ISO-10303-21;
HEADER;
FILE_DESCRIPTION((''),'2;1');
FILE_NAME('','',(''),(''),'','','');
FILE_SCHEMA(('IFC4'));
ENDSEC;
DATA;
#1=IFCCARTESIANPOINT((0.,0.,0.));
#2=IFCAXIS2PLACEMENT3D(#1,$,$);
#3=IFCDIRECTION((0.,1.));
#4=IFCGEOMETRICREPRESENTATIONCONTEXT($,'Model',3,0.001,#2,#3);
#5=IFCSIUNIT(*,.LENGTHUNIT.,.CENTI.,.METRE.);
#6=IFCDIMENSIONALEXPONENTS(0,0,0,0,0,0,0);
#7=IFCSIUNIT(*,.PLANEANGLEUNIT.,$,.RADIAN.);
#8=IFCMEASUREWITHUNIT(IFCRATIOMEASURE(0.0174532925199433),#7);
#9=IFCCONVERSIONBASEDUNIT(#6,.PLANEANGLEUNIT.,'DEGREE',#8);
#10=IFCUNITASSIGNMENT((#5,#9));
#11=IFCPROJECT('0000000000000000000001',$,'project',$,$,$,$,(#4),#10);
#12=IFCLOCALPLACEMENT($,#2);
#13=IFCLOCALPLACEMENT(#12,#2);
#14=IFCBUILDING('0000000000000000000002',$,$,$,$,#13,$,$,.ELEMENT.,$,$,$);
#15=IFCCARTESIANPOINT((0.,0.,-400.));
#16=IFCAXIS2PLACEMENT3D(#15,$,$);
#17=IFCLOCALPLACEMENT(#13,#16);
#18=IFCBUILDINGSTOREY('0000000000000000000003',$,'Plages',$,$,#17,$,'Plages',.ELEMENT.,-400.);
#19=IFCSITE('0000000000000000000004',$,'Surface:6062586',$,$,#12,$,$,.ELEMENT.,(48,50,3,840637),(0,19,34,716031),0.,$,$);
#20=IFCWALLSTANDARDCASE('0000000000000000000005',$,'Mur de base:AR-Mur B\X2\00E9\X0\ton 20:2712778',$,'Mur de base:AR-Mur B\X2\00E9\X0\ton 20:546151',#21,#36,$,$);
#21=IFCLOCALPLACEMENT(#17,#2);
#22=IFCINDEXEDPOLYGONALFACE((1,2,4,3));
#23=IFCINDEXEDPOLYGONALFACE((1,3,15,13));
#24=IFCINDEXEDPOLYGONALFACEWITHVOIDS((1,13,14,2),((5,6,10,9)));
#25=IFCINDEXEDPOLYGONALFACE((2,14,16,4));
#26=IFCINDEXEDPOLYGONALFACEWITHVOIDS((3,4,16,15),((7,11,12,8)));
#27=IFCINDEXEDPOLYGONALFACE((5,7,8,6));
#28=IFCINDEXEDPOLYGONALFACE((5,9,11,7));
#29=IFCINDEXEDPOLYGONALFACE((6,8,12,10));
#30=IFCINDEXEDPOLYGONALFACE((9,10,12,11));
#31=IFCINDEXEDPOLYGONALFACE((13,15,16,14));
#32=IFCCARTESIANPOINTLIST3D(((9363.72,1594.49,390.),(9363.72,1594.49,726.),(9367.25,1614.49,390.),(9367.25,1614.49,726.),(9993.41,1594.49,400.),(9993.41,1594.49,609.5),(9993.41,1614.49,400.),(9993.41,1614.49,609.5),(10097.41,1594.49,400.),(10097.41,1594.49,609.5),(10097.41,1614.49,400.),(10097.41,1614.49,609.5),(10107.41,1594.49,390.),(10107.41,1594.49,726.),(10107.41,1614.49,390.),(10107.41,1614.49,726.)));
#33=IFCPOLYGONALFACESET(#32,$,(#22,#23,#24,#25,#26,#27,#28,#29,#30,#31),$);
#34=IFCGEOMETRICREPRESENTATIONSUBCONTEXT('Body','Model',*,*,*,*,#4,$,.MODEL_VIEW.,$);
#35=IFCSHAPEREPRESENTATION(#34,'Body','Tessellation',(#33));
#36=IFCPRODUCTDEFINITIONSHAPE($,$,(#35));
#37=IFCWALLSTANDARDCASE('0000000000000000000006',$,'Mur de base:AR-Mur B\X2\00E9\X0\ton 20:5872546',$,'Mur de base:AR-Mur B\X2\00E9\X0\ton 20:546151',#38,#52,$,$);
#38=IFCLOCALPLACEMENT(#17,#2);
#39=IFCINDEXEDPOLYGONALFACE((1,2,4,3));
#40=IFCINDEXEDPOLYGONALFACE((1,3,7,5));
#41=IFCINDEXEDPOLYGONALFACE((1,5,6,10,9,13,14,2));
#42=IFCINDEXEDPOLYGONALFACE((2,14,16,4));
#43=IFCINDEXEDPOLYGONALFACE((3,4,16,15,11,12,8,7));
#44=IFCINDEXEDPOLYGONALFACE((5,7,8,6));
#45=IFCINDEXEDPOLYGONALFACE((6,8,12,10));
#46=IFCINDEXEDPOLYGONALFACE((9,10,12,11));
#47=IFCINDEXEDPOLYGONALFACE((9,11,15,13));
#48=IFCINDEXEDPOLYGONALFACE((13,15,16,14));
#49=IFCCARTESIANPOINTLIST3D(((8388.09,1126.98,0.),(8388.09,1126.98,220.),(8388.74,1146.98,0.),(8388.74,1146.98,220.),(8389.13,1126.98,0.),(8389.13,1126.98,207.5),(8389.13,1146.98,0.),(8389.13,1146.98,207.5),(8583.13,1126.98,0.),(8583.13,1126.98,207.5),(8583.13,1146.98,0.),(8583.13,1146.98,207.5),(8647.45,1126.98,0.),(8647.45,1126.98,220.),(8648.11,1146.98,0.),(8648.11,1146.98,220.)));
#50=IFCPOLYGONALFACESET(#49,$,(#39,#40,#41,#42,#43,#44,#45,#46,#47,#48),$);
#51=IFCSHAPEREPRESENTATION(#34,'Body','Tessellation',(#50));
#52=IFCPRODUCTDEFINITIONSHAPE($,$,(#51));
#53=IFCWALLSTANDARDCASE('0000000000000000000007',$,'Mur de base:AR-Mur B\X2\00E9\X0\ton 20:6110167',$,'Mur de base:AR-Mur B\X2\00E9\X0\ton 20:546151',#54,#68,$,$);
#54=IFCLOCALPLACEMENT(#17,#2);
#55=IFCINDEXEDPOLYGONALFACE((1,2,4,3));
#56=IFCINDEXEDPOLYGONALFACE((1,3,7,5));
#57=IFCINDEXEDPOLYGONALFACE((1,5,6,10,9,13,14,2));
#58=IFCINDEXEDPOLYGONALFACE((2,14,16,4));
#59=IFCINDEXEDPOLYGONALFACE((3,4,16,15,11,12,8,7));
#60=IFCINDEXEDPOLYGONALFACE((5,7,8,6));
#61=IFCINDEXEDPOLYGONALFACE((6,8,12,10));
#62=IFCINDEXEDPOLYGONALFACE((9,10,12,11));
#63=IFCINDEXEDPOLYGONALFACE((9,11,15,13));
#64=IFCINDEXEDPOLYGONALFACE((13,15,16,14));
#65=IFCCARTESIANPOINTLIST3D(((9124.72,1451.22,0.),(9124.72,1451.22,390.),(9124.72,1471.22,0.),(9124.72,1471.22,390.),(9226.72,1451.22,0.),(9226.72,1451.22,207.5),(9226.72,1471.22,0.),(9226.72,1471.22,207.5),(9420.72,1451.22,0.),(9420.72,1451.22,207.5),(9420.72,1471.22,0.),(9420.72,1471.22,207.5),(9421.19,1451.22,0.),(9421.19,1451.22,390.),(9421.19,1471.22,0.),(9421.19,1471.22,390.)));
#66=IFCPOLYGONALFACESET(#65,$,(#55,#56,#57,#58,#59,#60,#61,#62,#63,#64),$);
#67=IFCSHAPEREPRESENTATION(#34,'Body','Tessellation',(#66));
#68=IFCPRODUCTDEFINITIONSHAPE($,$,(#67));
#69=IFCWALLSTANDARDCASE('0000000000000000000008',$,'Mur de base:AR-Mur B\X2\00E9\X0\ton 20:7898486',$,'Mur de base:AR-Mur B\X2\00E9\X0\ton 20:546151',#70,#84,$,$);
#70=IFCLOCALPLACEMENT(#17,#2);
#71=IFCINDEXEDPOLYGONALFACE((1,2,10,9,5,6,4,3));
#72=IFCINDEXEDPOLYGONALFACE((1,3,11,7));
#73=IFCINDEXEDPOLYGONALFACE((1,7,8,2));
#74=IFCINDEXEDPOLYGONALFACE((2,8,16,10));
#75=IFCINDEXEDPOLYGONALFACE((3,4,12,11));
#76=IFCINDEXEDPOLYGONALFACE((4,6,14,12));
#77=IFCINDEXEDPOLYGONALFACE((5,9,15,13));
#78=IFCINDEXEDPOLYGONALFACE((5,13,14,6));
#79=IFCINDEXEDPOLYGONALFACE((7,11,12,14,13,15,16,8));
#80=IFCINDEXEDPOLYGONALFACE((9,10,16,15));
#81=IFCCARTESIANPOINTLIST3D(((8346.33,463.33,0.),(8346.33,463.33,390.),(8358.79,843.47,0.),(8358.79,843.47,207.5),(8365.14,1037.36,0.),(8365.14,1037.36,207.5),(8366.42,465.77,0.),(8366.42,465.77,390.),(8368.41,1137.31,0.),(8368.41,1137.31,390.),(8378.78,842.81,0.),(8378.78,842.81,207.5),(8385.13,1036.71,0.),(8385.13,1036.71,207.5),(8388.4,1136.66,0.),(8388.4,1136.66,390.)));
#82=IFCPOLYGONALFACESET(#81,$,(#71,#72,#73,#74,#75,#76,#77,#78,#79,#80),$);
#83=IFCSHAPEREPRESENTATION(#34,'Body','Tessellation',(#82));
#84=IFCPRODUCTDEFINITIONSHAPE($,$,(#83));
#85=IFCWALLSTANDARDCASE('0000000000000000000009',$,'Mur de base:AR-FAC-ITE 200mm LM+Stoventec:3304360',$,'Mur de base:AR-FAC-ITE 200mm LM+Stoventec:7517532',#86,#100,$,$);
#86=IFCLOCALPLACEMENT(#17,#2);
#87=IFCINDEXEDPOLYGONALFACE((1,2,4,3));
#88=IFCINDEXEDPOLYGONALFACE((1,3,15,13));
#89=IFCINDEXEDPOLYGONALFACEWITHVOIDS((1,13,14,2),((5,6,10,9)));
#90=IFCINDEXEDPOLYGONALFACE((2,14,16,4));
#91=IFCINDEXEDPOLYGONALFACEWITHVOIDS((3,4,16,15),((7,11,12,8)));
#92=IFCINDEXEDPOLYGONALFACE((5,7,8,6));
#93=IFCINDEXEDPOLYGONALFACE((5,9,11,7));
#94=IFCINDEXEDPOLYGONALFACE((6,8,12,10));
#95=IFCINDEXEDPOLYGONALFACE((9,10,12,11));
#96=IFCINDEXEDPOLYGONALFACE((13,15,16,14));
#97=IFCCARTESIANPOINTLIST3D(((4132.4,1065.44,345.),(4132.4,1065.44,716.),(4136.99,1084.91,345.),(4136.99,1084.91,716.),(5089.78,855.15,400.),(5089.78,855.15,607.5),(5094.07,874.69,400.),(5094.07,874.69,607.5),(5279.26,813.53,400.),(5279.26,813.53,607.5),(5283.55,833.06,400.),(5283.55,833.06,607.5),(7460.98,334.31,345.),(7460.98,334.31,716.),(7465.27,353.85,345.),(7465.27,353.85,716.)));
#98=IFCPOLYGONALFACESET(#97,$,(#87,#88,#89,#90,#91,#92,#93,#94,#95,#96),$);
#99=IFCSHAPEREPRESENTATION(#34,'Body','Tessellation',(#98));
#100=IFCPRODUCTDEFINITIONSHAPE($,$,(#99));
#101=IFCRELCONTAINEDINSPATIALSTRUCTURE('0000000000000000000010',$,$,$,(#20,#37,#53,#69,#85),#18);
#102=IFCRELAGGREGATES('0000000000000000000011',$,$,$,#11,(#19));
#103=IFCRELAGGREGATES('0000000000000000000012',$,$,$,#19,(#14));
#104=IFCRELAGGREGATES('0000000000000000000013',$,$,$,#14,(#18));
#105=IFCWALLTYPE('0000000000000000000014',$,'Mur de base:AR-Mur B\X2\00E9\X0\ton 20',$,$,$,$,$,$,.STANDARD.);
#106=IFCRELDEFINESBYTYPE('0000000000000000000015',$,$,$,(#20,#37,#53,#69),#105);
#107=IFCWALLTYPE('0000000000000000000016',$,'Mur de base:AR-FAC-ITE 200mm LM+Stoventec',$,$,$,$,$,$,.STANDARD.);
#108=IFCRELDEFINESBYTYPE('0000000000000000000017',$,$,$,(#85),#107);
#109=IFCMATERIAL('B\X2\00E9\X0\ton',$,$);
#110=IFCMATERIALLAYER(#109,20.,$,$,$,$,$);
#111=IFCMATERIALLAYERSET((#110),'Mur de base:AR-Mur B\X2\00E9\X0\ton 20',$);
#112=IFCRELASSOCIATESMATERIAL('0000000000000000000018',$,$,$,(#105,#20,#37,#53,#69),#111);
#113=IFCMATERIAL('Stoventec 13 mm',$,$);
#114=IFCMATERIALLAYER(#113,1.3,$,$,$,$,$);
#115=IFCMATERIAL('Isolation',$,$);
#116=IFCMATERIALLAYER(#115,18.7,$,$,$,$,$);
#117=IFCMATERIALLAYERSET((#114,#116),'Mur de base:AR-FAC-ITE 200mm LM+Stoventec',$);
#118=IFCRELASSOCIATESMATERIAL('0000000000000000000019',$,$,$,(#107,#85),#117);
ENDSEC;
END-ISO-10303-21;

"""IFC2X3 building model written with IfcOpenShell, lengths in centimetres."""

from ifc_helpers import new_model, entity, si_unit, converted_unit, direction, frame, frame_2d, origin, origin_2d_with_axis, place, context, subcontext, project, spatial, polyline, rectangle, outline, extrude, material, layer, layer_set, layer_usage, type_object, element, save


model = new_model("IFC2X3")

# Units and contexts
model_context = context("Model", 3, precision=0.001, world=origin(), true_north=direction((0.0, 1.0)))
body_context = subcontext(model_context, "Body", "Model", "MODEL_VIEW")
ifc_project = project(units=[si_unit("LENGTHUNIT", "METRE", prefix="CENTI"), converted_unit("PLANEANGLEUNIT", "DEGREE", entity("IfcRatioMeasure", 0.0174532925199433), si_unit("PLANEANGLEUNIT", "RADIAN"), dimensions=[0, 0, 0, 0, 0, 0, 0])], contexts=[model_context])

# Site, building, storey
site_placement = place(None, origin())
site = spatial("IfcSite", under=ifc_project, at=site_placement, Name="Surface:6062586", CompositionType="ELEMENT", RefLatitude=(48, 50, 3, 840637), RefLongitude=(0, 19, 34, 716031), RefElevation=0.0)
building_placement = place(site_placement, origin())
building = spatial("IfcBuilding", under=site, at=building_placement, CompositionType="ELEMENT")
storey_placement = place(building_placement, frame((0.0, 0.0, -400.0)))
storey = spatial("IfcBuildingStorey", under=building, at=storey_placement, Name="Plages", LongName="Plages", CompositionType="ELEMENT", Elevation=-400.0)

# Shared definitions
ifc_material_1 = material(Name="Béton")

# Wall, opening
ifc_layer_1 = layer(ifc_material_1, 20.0)
ifc_layer_set_1 = layer_set([ifc_layer_1], Name="Mur de base:AR-Mur Béton 20")
ifc_layer_usage_1 = layer_usage(ifc_layer_set_1, "AXIS2", "NEGATIVE", 10.0)
wall_type_1 = type_object("IfcWallType", Name="Mur de base:AR-Mur Béton 20", PredefinedType="STANDARD", material=ifc_layer_set_1)
wall_1_placement = place(storey_placement, frame((9363.72, 1604.49, 390.0)))
wall_1 = element("IfcWallStandardCase", 1, at=wall_1_placement, inside=storey, type_object=wall_type_1, material=ifc_layer_usage_1, Name="Mur de base:AR-Mur Béton 20:2712778", ObjectType="Mur de base:AR-Mur Béton 20:546151", context=body_context, shape_type="SweptSolid", body=[
    extrude(outline(polyline([(743.69, -10.0), (743.69, 10.0), (23.84, 10.0), (3.53, 10.0), (0.0, -10.0), (743.69, -10.0)])), origin(), (0.0, 0.0, 1.0), 336.0),
])
opening_1_placement = place(wall_1_placement, frame((629.69, -10.0, 10.0)))
element("IfcOpeningElement", 2, at=opening_1_placement, cuts=wall_1, ObjectType="Opening", context=body_context, shape_type="SweptSolid", body=[
    extrude(rectangle(XDim=209.5, YDim=104.0, at=frame_2d((104.75, 52.0), x_axis=(1.0, 0.0))), frame((0.0, 0.0, 0.0), z_axis=(0.0, 1.0, 0.0), x_axis=(0.0, 0.0, 1.0)), (0.0, 0.0, 1.0), 20.0),
])

# Wall, opening
ifc_layer_usage_2 = layer_usage(ifc_layer_set_1, "AXIS2", "NEGATIVE", 10.0)
wall_2_placement = place(storey_placement, frame((8388.09, 1136.98, 0.0)))
wall_2 = element("IfcWallStandardCase", 3, at=wall_2_placement, inside=storey, type_object=wall_type_1, material=ifc_layer_usage_2, Name="Mur de base:AR-Mur Béton 20:5872546", ObjectType="Mur de base:AR-Mur Béton 20:546151", context=body_context, shape_type="SweptSolid", body=[
    extrude(outline(polyline([(0.0, -10.0), (259.37, -10.0), (260.02, 10.0), (0.66, 10.0), (0.31, -0.65), (0.0, -10.0)])), origin(), (0.0, 0.0, 1.0), 220.0),
])
opening_2_placement = place(wall_2_placement, frame((1.05, -10.0, 0.0)))
element("IfcOpeningElement", 4, at=opening_2_placement, cuts=wall_2, ObjectType="Opening", context=body_context, shape_type="SweptSolid", body=[
    extrude(rectangle(XDim=207.5, YDim=194.0, at=frame_2d((103.75, 97.0), x_axis=(1.0, 0.0))), frame((0.0, 0.0, 0.0), z_axis=(0.0, 1.0, 0.0), x_axis=(0.0, 0.0, 1.0)), (0.0, 0.0, 1.0), 20.0),
])

# Walls, openings
ifc_layer_usage_3 = layer_usage(ifc_layer_set_1, "AXIS2", "NEGATIVE", 10.0)
wall_3_placement = place(storey_placement, frame((9124.72, 1461.22, 0.0)))
wall_3 = element("IfcWallStandardCase", 5, at=wall_3_placement, inside=storey, type_object=wall_type_1, material=ifc_layer_usage_3, Name="Mur de base:AR-Mur Béton 20:6110167", ObjectType="Mur de base:AR-Mur Béton 20:546151", context=body_context, shape_type="SweptSolid", body=[
    extrude(rectangle(XDim=296.47, YDim=20.0, at=frame_2d((148.23, 0.0), x_axis=(-1.0, 0.0))), origin(), (0.0, 0.0, 1.0), 390.0),
])
opening_3_placement = place(wall_3_placement, frame((296.0, 10.0, 0.0)))
element("IfcOpeningElement", 6, at=opening_3_placement, cuts=wall_3, ObjectType="Opening", context=body_context, shape_type="SweptSolid", body=[
    extrude(rectangle(XDim=207.5, YDim=194.0, at=frame_2d((103.75, 97.0), x_axis=(1.0, 0.0))), frame((0.0, 0.0, 0.0), z_axis=(0.0, -1.0, 0.0), x_axis=(0.0, 0.0, 1.0)), (0.0, 0.0, 1.0), 20.0),
])
ifc_layer_usage_4 = layer_usage(ifc_layer_set_1, "AXIS2", "NEGATIVE", 10.0)
wall_4_placement = place(storey_placement, frame((8378.41, 1136.98, 0.0), z_axis=(0.0, 0.0, 1.0), x_axis=(-0.032747, -0.999464, 0.0)))
wall_4 = element("IfcWallStandardCase", 7, at=wall_4_placement, inside=storey, type_object=wall_type_1, material=ifc_layer_usage_4, Name="Mur de base:AR-Mur Béton 20:7898486", ObjectType="Mur de base:AR-Mur Béton 20:546151", context=body_context, shape_type="SweptSolid", body=[
    extrude(outline(polyline([(0.0, -10.0), (674.34, -10.0), (671.24, 10.0), (0.0, 10.0), (0.0, -10.0)])), origin(), (0.0, 0.0, 1.0), 390.0),
])
opening_4_placement = place(wall_4_placement, frame((100.0, -10.0, 0.0)))
element("IfcOpeningElement", 8, at=opening_4_placement, cuts=wall_4, ObjectType="Opening", context=body_context, shape_type="SweptSolid", body=[
    extrude(rectangle(XDim=207.5, YDim=194.0, at=frame_2d((103.75, 97.0), x_axis=(1.0, 0.0))), frame((0.0, 0.0, 0.0), z_axis=(0.0, 1.0, 0.0), x_axis=(0.0, 0.0, 1.0)), (0.0, 0.0, 1.0), 20.0),
])

# Shared definitions
ifc_material_2 = material(Name="Stoventec 13 mm")
ifc_layer_2 = layer(ifc_material_2, 1.3)
ifc_material_3 = material(Name="Isolation")
ifc_layer_3 = layer(ifc_material_3, 18.7)
ifc_layer_set_2 = layer_set([ifc_layer_2, ifc_layer_3], Name="Mur de base:AR-FAC-ITE 200mm LM+Stoventec")
wall_type_2 = type_object("IfcWallType", Name="Mur de base:AR-FAC-ITE 200mm LM+Stoventec", PredefinedType="STANDARD", material=ifc_layer_set_2)

# Wall, opening
ifc_layer_usage_5 = layer_usage(ifc_layer_set_2, "AXIS2", "NEGATIVE", 10.0)
wall_5_placement = place(storey_placement, frame((7463.12, 344.08, 345.0), z_axis=(0.0, 0.0, 1.0), x_axis=(-0.976716, 0.214538, 0.0)))
wall_5 = element("IfcWallStandardCase", 9, at=wall_5_placement, inside=storey, type_object=wall_type_2, material=ifc_layer_usage_5, Name="Mur de base:AR-FAC-ITE 200mm LM+Stoventec:3304360", ObjectType="Mur de base:AR-FAC-ITE 200mm LM+Stoventec:7517532", context=body_context, shape_type="SweptSolid", body=[
    extrude(outline(polyline([(3407.62, -10.0), (3407.92, 10.0), (0.0, 10.0), (0.0, -10.0), (3407.62, -10.0)])), origin(), (0.0, 0.0, 1.0), 371.0),
])
opening_5_placement = place(wall_5_placement, frame((2418.8, 50.65, 55.0)))
element("IfcOpeningElement", 10, at=opening_5_placement, cuts=wall_5, ObjectType="Opening", context=body_context, shape_type="SweptSolid", body=[
    extrude(rectangle(XDim=207.5, YDim=194.0, at=origin_2d_with_axis()), frame((-88.07, -60.65, 103.75), z_axis=(0.0, 1.0, 0.0), x_axis=(0.0, 0.0, -1.0)), (0.0, 0.0, 1.0), 20.0),
])

save(model, "model.ifc")
